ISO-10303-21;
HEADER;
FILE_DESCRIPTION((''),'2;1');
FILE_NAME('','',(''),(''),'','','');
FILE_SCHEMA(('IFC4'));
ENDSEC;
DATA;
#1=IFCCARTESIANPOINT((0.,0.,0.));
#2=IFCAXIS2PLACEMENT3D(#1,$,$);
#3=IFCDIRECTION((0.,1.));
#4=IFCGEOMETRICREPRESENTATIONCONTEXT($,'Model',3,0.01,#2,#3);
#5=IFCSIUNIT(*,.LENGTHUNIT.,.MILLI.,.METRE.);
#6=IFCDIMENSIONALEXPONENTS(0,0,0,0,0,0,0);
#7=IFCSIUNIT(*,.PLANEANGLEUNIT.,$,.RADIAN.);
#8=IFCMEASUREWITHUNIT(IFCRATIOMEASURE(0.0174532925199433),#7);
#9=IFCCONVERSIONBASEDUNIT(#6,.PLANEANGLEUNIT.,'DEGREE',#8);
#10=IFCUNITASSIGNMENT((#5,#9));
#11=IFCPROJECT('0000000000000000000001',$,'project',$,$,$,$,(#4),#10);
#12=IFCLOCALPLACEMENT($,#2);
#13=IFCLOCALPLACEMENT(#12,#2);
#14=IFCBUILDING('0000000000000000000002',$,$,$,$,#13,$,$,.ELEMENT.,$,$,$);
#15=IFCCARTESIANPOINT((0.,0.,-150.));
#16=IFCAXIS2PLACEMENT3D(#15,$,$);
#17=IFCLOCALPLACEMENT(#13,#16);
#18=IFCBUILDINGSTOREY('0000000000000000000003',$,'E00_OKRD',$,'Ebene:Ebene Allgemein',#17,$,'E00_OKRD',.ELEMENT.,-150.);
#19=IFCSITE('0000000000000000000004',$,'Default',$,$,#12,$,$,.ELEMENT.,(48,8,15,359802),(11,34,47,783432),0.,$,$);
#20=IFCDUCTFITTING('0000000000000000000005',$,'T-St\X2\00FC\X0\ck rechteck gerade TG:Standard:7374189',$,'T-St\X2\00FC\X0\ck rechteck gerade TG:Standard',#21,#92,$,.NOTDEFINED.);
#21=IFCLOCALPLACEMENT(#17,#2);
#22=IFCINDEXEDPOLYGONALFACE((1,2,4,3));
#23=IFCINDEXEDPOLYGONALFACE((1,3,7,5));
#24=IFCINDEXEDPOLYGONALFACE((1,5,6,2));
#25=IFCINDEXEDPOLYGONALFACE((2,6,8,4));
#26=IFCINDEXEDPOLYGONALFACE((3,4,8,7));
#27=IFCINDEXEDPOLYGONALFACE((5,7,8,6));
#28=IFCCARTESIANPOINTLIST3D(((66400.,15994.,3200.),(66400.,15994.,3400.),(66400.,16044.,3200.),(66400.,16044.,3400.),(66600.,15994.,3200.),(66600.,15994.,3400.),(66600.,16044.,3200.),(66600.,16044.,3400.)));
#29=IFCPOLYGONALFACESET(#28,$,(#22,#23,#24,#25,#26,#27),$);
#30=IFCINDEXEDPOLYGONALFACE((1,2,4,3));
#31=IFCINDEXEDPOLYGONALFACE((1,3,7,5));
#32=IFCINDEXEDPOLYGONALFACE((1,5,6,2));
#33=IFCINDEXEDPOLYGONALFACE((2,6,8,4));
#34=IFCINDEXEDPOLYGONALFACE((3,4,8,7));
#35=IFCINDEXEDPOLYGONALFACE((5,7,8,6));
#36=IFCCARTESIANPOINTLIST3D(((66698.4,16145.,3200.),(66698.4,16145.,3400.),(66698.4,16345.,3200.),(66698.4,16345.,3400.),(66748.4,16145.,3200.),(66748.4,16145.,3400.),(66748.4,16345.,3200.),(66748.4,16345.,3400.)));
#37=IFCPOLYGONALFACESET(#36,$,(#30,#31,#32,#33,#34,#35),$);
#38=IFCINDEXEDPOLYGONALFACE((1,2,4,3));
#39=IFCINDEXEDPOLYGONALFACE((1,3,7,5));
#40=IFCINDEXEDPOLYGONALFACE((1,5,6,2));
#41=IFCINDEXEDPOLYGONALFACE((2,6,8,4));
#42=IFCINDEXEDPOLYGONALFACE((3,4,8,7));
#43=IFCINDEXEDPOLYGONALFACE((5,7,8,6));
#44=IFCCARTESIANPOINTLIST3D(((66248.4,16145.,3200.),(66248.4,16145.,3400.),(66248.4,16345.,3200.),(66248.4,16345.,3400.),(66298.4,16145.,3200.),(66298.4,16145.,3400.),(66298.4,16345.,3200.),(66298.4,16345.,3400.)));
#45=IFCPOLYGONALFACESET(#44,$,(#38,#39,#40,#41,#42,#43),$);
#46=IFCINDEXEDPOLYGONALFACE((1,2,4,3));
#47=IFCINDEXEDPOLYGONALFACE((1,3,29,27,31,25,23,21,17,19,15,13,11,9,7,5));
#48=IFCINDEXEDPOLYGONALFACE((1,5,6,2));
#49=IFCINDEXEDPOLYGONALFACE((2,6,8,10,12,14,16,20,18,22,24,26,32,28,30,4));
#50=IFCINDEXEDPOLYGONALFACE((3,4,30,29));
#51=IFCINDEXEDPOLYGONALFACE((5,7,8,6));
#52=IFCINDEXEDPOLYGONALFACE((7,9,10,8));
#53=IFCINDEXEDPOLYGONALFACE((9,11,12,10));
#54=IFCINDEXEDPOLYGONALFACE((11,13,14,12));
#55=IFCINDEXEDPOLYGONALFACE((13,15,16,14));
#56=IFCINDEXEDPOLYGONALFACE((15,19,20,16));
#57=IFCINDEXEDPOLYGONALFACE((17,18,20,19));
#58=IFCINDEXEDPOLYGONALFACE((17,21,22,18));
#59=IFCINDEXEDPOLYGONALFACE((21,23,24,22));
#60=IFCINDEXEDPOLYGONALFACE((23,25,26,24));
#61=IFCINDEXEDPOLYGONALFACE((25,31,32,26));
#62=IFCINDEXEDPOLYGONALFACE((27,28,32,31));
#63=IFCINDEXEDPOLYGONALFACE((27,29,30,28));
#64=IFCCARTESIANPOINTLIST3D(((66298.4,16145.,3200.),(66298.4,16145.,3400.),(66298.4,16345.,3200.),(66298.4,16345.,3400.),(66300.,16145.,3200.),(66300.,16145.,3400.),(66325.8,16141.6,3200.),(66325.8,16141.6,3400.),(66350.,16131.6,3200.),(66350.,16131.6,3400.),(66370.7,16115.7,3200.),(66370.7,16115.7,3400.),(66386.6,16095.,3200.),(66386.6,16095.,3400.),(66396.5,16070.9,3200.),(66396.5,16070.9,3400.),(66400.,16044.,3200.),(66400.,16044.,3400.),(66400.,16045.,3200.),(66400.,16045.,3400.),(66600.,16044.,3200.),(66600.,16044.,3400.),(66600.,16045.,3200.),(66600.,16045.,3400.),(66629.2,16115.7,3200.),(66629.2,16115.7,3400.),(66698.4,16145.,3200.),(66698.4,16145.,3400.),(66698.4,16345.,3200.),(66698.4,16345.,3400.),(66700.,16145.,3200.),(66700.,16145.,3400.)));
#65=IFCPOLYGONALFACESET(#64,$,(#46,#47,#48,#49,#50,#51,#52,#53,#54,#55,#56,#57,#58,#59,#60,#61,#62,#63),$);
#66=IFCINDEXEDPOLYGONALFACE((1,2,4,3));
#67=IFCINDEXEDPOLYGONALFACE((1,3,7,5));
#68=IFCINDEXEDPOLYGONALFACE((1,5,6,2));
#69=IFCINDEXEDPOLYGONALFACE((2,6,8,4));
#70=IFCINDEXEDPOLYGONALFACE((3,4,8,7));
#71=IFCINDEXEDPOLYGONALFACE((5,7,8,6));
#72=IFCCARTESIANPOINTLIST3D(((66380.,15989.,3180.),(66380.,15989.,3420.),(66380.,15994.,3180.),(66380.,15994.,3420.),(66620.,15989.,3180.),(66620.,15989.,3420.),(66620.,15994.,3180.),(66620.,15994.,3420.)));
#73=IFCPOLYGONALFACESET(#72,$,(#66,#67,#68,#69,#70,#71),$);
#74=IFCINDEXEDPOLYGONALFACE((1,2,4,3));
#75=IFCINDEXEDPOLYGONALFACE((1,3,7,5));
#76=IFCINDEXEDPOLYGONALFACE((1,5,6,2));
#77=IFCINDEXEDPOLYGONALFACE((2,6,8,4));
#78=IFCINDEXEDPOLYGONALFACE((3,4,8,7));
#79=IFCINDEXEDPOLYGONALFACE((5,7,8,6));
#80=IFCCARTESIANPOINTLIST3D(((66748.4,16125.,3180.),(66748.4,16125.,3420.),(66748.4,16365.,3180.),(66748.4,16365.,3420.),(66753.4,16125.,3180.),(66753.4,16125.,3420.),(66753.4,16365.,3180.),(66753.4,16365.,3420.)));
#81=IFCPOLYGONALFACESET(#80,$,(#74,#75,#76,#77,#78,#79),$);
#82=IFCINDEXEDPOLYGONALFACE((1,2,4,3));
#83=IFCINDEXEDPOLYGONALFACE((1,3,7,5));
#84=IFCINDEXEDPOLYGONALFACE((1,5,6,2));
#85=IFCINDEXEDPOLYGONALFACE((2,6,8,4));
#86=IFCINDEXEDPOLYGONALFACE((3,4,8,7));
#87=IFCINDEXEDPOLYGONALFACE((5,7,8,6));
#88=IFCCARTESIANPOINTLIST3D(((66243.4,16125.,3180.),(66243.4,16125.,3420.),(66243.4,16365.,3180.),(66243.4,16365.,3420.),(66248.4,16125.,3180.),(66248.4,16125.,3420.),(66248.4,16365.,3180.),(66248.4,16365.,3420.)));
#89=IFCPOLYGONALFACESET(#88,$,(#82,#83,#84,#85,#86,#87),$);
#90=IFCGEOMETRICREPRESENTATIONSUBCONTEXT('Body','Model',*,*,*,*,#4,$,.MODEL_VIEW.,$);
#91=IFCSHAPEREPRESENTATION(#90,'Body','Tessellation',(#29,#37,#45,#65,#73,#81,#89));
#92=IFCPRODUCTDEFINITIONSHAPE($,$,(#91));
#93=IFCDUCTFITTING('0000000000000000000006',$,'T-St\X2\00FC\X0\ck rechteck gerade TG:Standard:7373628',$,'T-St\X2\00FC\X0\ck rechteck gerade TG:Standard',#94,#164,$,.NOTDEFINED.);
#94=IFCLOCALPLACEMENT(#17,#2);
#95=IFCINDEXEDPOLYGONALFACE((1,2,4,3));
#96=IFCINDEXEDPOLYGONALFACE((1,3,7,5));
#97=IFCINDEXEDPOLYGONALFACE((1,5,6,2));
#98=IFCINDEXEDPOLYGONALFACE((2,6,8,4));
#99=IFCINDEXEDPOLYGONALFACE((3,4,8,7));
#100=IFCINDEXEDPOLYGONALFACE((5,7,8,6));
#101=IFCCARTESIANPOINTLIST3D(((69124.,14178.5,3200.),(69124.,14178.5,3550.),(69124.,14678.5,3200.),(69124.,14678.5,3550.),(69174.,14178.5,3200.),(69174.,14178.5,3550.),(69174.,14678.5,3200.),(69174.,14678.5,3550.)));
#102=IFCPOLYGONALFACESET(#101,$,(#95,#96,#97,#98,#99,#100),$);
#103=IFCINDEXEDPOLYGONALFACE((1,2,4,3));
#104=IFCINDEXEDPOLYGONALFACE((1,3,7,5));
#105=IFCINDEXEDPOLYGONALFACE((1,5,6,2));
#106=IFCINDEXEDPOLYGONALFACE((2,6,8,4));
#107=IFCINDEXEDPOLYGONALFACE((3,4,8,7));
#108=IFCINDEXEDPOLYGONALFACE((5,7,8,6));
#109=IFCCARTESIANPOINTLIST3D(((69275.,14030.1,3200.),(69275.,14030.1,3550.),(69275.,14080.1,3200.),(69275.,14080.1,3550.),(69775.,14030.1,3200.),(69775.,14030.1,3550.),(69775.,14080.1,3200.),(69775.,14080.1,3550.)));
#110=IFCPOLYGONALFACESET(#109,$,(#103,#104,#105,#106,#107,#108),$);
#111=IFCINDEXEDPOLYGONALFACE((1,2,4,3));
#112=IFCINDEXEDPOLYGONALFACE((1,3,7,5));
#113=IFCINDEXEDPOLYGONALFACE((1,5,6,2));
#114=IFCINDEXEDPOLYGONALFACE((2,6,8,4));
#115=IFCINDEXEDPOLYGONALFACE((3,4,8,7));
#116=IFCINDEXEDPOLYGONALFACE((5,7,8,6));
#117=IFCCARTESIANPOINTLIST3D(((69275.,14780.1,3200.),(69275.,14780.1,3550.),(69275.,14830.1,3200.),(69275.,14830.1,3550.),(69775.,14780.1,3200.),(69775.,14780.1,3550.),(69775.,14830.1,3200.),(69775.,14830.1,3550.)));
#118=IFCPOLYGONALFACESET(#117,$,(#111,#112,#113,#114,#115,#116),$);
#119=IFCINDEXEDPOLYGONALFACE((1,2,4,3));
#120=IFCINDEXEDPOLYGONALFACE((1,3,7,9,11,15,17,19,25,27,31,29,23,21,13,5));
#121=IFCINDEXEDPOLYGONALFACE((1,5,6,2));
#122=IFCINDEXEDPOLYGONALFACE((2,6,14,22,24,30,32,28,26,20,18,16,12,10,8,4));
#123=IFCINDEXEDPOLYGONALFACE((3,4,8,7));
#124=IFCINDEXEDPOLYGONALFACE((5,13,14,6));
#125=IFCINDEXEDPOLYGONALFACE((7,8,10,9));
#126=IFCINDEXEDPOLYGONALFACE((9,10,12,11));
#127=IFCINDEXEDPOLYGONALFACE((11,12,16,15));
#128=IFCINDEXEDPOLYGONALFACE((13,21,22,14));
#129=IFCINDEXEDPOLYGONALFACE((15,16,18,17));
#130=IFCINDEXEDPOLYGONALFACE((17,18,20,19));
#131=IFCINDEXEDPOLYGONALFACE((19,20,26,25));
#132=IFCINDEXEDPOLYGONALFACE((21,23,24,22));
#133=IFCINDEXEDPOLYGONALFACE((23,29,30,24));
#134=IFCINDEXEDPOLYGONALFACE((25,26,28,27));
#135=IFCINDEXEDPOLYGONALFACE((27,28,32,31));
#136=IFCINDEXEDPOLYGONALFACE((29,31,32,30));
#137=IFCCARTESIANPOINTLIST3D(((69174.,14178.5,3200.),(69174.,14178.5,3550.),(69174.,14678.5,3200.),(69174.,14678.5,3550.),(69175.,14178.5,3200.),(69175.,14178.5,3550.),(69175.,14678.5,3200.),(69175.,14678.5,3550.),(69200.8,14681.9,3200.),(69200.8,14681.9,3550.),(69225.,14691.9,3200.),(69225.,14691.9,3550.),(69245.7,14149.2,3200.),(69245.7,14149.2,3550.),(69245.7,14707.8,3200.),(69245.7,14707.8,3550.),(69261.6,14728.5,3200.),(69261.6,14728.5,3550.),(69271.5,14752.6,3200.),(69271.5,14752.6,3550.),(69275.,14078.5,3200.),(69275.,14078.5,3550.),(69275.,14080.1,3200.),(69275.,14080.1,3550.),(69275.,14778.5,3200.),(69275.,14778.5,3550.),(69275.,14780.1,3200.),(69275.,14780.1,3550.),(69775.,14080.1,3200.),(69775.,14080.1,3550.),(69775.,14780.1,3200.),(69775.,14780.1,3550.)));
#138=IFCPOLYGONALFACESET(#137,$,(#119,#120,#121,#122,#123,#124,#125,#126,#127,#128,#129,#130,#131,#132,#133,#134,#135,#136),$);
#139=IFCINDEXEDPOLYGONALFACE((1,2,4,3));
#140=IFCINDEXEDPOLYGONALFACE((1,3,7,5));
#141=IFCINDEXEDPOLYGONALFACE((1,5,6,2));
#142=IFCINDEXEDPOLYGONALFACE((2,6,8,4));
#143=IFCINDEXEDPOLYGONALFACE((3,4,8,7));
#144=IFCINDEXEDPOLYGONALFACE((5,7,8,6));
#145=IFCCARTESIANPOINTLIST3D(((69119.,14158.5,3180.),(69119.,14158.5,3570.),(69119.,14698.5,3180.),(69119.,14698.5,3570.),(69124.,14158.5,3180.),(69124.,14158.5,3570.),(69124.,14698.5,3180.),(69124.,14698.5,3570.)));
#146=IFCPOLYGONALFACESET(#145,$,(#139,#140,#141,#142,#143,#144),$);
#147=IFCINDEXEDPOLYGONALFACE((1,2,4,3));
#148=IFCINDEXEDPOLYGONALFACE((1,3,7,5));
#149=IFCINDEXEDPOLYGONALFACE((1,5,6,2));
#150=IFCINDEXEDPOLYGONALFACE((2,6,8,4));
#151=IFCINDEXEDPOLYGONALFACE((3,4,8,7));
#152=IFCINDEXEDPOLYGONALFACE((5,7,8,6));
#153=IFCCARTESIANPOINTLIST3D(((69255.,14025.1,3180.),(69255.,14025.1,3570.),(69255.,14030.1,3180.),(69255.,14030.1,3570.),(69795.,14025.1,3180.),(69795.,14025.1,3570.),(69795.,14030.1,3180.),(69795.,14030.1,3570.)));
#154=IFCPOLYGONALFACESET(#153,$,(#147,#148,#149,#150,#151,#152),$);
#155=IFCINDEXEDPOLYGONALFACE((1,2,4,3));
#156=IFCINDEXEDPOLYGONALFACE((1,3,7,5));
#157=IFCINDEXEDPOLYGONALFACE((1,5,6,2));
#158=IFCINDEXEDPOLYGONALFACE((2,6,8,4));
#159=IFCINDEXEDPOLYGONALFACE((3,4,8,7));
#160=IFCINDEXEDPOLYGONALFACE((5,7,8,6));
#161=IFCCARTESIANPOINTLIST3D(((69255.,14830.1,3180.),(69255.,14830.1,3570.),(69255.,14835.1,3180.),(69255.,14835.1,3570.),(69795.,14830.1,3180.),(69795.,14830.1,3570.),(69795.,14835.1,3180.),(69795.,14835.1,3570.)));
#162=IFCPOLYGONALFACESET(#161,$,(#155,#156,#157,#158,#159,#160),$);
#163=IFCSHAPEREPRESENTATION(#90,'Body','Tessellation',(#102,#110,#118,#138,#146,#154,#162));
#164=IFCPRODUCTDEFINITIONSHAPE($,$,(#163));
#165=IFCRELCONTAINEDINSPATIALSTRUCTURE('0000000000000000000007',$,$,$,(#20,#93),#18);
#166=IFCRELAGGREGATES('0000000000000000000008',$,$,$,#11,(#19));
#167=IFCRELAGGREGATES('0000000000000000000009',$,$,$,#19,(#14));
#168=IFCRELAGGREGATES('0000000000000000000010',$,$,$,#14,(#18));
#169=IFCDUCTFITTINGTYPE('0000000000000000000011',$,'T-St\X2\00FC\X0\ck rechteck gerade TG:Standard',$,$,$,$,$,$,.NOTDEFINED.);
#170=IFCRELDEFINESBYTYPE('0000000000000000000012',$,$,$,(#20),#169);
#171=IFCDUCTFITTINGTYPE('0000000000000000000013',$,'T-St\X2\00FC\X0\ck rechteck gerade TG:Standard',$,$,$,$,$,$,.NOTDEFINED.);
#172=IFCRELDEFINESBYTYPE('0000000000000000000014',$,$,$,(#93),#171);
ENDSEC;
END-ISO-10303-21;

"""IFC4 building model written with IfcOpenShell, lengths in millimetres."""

from ifc_helpers import new_model, entity, si_unit, converted_unit, direction, frame, frame_2d, origin, origin_2d_with_axis, place, context, subcontext, project, spatial, polyline, circle_curve, parameter, trimmed, segment, composite_curve, rectangle, outline, extrude, source, transform, mapped, type_object, type_shapes, element, save


model = new_model("IFC4")

# Units and contexts
model_context = context("Model", 3, precision=0.01, world=origin(), true_north=direction((0.0, 1.0)))
body_context = subcontext(model_context, "Body", "Model", "MODEL_VIEW")
ifc_project = project(units=[si_unit("LENGTHUNIT", "METRE", prefix="MILLI"), converted_unit("PLANEANGLEUNIT", "DEGREE", entity("IfcRatioMeasure", 0.0174532925199433), si_unit("PLANEANGLEUNIT", "RADIAN"), dimensions=[0, 0, 0, 0, 0, 0, 0])], contexts=[model_context])

# Site, building, storey
site_placement = place(None, origin())
site = spatial("IfcSite", under=ifc_project, at=site_placement, Name="Default", CompositionType="ELEMENT", RefLatitude=(48, 8, 15, 359802), RefLongitude=(11, 34, 47, 783432), RefElevation=0.0)
building_placement = place(site_placement, origin())
building = spatial("IfcBuilding", under=site, at=building_placement, CompositionType="ELEMENT")
storey_placement = place(building_placement, frame((0.0, 0.0, -150.0)))
storey = spatial("IfcBuildingStorey", under=building, at=storey_placement, Name="E00_OKRD", ObjectType="Ebene:Ebene Allgemein", LongName="E00_OKRD", CompositionType="ELEMENT", Elevation=-150.0)

# Duct fittings
duct_fitting_type_1 = type_object("IfcDuctFittingType", Name="T-Stück rechteck gerade TG:Standard", PredefinedType="NOTDEFINED")
shared_shape_1 = source(origin(), body_context, "Body", "SweptSolid", [
    extrude(rectangle(XDim=50.0, YDim=200.0, at=frame_2d((0.0, 0.0), x_axis=(1.0, 0.0))), frame((0.0, -226.0, -100.0), z_axis=(0.0, 0.0, 1.0), x_axis=(0.0, -1.0, 0.0)), (0.0, 0.0, 1.0), 200.0),
    extrude(rectangle(XDim=50.0, YDim=200.0, at=frame_2d((0.0, 0.0), x_axis=(1.0, 0.0))), frame((223.4, 0.0, -100.0), z_axis=(0.0, 0.0, 1.0), x_axis=(-1.0, 0.0, 0.0)), (0.0, 0.0, 1.0), 200.0),
    extrude(rectangle(XDim=50.0, YDim=200.0, at=frame_2d((0.0, 0.0), x_axis=(1.0, 0.0))), frame((-226.6, 0.0, -100.0)), (0.0, 0.0, 1.0), 200.0),
    extrude(outline(composite_curve([segment(trimmed(circle_curve(frame_2d((-200.6, -99.8), x_axis=(-1.0, 0.0)), 100.0), [parameter(180.0)], [parameter(270.0)], True, "PARAMETER"), False, "CONTINUOUS"), segment(polyline([(-100.6, -99.8), (-100.6, -100.8)]), True, "CONTINUOUS"), segment(polyline([(-100.6, -100.8), (99.4, -100.8)]), True, "CONTINUOUS"), segment(polyline([(99.4, -100.8), (99.4, -99.8)]), True, "CONTINUOUS"), segment(trimmed(circle_curve(frame_2d((199.4, -99.8), x_axis=(-1.0, 0.0)), 100.0), [parameter(270.0)], [parameter(0.0)], True, "PARAMETER"), False, "CONTINUOUS"), segment(polyline([(199.4, 0.2), (201.0, 0.2)]), True, "CONTINUOUS"), segment(polyline([(201.0, 0.2), (201.0, 200.2)]), True, "CONTINUOUS"), segment(polyline([(201.0, 200.2), (-199.0, 200.2)]), True, "CONTINUOUS"), segment(polyline([(-199.0, 200.2), (-199.0, 0.2)]), True, "CONTINUOUS"), segment(polyline([(-199.0, 0.2), (-200.6, 0.2)]), True, "CONTINUOUS")], self_intersect=False)), frame((-0.6, -100.2, -100.0), z_axis=(0.0, 0.0, -1.0), x_axis=(-1.0, 0.0, 0.0)), (0.0, 0.0, -1.0), 200.0),
    extrude(rectangle(XDim=5.0, YDim=240.0, at=frame_2d((0.0, 0.0), x_axis=(1.0, 0.0))), frame((0.0, -253.5, -120.0), z_axis=(0.0, 0.0, 1.0), x_axis=(0.0, 1.0, 0.0)), (0.0, 0.0, 1.0), 240.0),
    extrude(rectangle(XDim=5.0, YDim=240.0, at=origin_2d_with_axis()), frame((250.9, 0.0, -120.0), z_axis=(0.0, 0.0, 1.0), x_axis=(-1.0, 0.0, 0.0)), (0.0, 0.0, 1.0), 240.0),
    extrude(rectangle(XDim=5.0, YDim=240.0, at=origin_2d_with_axis()), frame((-254.1, 0.0, -120.0), z_axis=(0.0, 0.0, 1.0), x_axis=(-1.0, 0.0, 0.0)), (0.0, 0.0, 1.0), 240.0),
])
type_shapes(duct_fitting_type_1, [shared_shape_1])
duct_fitting_1_placement = place(storey_placement, frame((66500.0, 16245.0, 3300.0)))
element("IfcDuctFitting", 1, at=duct_fitting_1_placement, inside=storey, type_object=duct_fitting_type_1, Name="T-Stück rechteck gerade TG:Standard:7374189", ObjectType="T-Stück rechteck gerade TG:Standard", PredefinedType="NOTDEFINED", context=body_context, shape_type="MappedRepresentation", body=[
    mapped(shared_shape_1, transform((0.0, 0.0, 0.0), scale=1.0)),
])
duct_fitting_type_2 = type_object("IfcDuctFittingType", Name="T-Stück rechteck gerade TG:Standard", PredefinedType="NOTDEFINED")
shared_shape_2 = source(origin(), body_context, "Body", "SweptSolid", [
    extrude(rectangle(XDim=50.0, YDim=500.0, at=origin_2d_with_axis()), frame((0.0, -376.0, -175.0), z_axis=(0.0, 0.0, 1.0), x_axis=(0.0, -1.0, 0.0)), (0.0, 0.0, 1.0), 350.0),
    extrude(rectangle(XDim=50.0, YDim=500.0, at=origin_2d_with_axis()), frame((373.4, 0.0, -175.0), z_axis=(0.0, 0.0, 1.0), x_axis=(-1.0, 0.0, 0.0)), (0.0, 0.0, 1.0), 350.0),
    extrude(rectangle(XDim=50.0, YDim=500.0, at=origin_2d_with_axis()), frame((-376.6, 0.0, -175.0)), (0.0, 0.0, 1.0), 350.0),
    extrude(outline(composite_curve([segment(trimmed(circle_curve(frame_2d((-350.6, -159.8), x_axis=(-1.0, 0.0)), 100.0), [parameter(180.0)], [parameter(270.0)], True, "PARAMETER"), False, "CONTINUOUS"), segment(polyline([(-250.6, -159.8), (-250.6, -160.8)]), True, "CONTINUOUS"), segment(polyline([(-250.6, -160.8), (249.4, -160.8)]), True, "CONTINUOUS"), segment(polyline([(249.4, -160.8), (249.4, -159.8)]), True, "CONTINUOUS"), segment(trimmed(circle_curve(frame_2d((349.4, -159.8), x_axis=(-1.0, 0.0)), 100.0), [parameter(270.0)], [parameter(0.0)], True, "PARAMETER"), False, "CONTINUOUS"), segment(polyline([(349.4, -59.8), (351.0, -59.8)]), True, "CONTINUOUS"), segment(polyline([(351.0, -59.8), (351.0, 440.2)]), True, "CONTINUOUS"), segment(polyline([(351.0, 440.2), (-349.0, 440.2)]), True, "CONTINUOUS"), segment(polyline([(-349.0, 440.2), (-349.0, -59.8)]), True, "CONTINUOUS"), segment(polyline([(-349.0, -59.8), (-350.6, -59.8)]), True, "CONTINUOUS")], self_intersect=False)), frame((-0.6, -190.2, -175.0), z_axis=(0.0, 0.0, -1.0), x_axis=(-1.0, 0.0, 0.0)), (0.0, 0.0, -1.0), 350.0),
    extrude(rectangle(XDim=5.0, YDim=540.0, at=origin_2d_with_axis()), frame((0.0, -403.5, -195.0), z_axis=(0.0, 0.0, 1.0), x_axis=(0.0, 1.0, 0.0)), (0.0, 0.0, 1.0), 390.0),
    extrude(rectangle(XDim=5.0, YDim=540.0, at=origin_2d_with_axis()), frame((400.9, 0.0, -195.0), z_axis=(0.0, 0.0, 1.0), x_axis=(-1.0, 0.0, 0.0)), (0.0, 0.0, 1.0), 390.0),
    extrude(rectangle(XDim=5.0, YDim=540.0, at=origin_2d_with_axis()), frame((-404.1, 0.0, -195.0), z_axis=(0.0, 0.0, 1.0), x_axis=(-1.0, 0.0, 0.0)), (0.0, 0.0, 1.0), 390.0),
])
type_shapes(duct_fitting_type_2, [shared_shape_2])
duct_fitting_2_placement = place(storey_placement, frame((69525.0, 14428.5, 3375.0), z_axis=(0.0, 0.0, 1.0), x_axis=(0.0, -1.0, 0.0)))
element("IfcDuctFitting", 2, at=duct_fitting_2_placement, inside=storey, type_object=duct_fitting_type_2, Name="T-Stück rechteck gerade TG:Standard:7373628", ObjectType="T-Stück rechteck gerade TG:Standard", PredefinedType="NOTDEFINED", context=body_context, shape_type="MappedRepresentation", body=[
    mapped(shared_shape_2, transform((0.0, 0.0, 0.0), scale=1.0)),
])

save(model, "model.ifc")
